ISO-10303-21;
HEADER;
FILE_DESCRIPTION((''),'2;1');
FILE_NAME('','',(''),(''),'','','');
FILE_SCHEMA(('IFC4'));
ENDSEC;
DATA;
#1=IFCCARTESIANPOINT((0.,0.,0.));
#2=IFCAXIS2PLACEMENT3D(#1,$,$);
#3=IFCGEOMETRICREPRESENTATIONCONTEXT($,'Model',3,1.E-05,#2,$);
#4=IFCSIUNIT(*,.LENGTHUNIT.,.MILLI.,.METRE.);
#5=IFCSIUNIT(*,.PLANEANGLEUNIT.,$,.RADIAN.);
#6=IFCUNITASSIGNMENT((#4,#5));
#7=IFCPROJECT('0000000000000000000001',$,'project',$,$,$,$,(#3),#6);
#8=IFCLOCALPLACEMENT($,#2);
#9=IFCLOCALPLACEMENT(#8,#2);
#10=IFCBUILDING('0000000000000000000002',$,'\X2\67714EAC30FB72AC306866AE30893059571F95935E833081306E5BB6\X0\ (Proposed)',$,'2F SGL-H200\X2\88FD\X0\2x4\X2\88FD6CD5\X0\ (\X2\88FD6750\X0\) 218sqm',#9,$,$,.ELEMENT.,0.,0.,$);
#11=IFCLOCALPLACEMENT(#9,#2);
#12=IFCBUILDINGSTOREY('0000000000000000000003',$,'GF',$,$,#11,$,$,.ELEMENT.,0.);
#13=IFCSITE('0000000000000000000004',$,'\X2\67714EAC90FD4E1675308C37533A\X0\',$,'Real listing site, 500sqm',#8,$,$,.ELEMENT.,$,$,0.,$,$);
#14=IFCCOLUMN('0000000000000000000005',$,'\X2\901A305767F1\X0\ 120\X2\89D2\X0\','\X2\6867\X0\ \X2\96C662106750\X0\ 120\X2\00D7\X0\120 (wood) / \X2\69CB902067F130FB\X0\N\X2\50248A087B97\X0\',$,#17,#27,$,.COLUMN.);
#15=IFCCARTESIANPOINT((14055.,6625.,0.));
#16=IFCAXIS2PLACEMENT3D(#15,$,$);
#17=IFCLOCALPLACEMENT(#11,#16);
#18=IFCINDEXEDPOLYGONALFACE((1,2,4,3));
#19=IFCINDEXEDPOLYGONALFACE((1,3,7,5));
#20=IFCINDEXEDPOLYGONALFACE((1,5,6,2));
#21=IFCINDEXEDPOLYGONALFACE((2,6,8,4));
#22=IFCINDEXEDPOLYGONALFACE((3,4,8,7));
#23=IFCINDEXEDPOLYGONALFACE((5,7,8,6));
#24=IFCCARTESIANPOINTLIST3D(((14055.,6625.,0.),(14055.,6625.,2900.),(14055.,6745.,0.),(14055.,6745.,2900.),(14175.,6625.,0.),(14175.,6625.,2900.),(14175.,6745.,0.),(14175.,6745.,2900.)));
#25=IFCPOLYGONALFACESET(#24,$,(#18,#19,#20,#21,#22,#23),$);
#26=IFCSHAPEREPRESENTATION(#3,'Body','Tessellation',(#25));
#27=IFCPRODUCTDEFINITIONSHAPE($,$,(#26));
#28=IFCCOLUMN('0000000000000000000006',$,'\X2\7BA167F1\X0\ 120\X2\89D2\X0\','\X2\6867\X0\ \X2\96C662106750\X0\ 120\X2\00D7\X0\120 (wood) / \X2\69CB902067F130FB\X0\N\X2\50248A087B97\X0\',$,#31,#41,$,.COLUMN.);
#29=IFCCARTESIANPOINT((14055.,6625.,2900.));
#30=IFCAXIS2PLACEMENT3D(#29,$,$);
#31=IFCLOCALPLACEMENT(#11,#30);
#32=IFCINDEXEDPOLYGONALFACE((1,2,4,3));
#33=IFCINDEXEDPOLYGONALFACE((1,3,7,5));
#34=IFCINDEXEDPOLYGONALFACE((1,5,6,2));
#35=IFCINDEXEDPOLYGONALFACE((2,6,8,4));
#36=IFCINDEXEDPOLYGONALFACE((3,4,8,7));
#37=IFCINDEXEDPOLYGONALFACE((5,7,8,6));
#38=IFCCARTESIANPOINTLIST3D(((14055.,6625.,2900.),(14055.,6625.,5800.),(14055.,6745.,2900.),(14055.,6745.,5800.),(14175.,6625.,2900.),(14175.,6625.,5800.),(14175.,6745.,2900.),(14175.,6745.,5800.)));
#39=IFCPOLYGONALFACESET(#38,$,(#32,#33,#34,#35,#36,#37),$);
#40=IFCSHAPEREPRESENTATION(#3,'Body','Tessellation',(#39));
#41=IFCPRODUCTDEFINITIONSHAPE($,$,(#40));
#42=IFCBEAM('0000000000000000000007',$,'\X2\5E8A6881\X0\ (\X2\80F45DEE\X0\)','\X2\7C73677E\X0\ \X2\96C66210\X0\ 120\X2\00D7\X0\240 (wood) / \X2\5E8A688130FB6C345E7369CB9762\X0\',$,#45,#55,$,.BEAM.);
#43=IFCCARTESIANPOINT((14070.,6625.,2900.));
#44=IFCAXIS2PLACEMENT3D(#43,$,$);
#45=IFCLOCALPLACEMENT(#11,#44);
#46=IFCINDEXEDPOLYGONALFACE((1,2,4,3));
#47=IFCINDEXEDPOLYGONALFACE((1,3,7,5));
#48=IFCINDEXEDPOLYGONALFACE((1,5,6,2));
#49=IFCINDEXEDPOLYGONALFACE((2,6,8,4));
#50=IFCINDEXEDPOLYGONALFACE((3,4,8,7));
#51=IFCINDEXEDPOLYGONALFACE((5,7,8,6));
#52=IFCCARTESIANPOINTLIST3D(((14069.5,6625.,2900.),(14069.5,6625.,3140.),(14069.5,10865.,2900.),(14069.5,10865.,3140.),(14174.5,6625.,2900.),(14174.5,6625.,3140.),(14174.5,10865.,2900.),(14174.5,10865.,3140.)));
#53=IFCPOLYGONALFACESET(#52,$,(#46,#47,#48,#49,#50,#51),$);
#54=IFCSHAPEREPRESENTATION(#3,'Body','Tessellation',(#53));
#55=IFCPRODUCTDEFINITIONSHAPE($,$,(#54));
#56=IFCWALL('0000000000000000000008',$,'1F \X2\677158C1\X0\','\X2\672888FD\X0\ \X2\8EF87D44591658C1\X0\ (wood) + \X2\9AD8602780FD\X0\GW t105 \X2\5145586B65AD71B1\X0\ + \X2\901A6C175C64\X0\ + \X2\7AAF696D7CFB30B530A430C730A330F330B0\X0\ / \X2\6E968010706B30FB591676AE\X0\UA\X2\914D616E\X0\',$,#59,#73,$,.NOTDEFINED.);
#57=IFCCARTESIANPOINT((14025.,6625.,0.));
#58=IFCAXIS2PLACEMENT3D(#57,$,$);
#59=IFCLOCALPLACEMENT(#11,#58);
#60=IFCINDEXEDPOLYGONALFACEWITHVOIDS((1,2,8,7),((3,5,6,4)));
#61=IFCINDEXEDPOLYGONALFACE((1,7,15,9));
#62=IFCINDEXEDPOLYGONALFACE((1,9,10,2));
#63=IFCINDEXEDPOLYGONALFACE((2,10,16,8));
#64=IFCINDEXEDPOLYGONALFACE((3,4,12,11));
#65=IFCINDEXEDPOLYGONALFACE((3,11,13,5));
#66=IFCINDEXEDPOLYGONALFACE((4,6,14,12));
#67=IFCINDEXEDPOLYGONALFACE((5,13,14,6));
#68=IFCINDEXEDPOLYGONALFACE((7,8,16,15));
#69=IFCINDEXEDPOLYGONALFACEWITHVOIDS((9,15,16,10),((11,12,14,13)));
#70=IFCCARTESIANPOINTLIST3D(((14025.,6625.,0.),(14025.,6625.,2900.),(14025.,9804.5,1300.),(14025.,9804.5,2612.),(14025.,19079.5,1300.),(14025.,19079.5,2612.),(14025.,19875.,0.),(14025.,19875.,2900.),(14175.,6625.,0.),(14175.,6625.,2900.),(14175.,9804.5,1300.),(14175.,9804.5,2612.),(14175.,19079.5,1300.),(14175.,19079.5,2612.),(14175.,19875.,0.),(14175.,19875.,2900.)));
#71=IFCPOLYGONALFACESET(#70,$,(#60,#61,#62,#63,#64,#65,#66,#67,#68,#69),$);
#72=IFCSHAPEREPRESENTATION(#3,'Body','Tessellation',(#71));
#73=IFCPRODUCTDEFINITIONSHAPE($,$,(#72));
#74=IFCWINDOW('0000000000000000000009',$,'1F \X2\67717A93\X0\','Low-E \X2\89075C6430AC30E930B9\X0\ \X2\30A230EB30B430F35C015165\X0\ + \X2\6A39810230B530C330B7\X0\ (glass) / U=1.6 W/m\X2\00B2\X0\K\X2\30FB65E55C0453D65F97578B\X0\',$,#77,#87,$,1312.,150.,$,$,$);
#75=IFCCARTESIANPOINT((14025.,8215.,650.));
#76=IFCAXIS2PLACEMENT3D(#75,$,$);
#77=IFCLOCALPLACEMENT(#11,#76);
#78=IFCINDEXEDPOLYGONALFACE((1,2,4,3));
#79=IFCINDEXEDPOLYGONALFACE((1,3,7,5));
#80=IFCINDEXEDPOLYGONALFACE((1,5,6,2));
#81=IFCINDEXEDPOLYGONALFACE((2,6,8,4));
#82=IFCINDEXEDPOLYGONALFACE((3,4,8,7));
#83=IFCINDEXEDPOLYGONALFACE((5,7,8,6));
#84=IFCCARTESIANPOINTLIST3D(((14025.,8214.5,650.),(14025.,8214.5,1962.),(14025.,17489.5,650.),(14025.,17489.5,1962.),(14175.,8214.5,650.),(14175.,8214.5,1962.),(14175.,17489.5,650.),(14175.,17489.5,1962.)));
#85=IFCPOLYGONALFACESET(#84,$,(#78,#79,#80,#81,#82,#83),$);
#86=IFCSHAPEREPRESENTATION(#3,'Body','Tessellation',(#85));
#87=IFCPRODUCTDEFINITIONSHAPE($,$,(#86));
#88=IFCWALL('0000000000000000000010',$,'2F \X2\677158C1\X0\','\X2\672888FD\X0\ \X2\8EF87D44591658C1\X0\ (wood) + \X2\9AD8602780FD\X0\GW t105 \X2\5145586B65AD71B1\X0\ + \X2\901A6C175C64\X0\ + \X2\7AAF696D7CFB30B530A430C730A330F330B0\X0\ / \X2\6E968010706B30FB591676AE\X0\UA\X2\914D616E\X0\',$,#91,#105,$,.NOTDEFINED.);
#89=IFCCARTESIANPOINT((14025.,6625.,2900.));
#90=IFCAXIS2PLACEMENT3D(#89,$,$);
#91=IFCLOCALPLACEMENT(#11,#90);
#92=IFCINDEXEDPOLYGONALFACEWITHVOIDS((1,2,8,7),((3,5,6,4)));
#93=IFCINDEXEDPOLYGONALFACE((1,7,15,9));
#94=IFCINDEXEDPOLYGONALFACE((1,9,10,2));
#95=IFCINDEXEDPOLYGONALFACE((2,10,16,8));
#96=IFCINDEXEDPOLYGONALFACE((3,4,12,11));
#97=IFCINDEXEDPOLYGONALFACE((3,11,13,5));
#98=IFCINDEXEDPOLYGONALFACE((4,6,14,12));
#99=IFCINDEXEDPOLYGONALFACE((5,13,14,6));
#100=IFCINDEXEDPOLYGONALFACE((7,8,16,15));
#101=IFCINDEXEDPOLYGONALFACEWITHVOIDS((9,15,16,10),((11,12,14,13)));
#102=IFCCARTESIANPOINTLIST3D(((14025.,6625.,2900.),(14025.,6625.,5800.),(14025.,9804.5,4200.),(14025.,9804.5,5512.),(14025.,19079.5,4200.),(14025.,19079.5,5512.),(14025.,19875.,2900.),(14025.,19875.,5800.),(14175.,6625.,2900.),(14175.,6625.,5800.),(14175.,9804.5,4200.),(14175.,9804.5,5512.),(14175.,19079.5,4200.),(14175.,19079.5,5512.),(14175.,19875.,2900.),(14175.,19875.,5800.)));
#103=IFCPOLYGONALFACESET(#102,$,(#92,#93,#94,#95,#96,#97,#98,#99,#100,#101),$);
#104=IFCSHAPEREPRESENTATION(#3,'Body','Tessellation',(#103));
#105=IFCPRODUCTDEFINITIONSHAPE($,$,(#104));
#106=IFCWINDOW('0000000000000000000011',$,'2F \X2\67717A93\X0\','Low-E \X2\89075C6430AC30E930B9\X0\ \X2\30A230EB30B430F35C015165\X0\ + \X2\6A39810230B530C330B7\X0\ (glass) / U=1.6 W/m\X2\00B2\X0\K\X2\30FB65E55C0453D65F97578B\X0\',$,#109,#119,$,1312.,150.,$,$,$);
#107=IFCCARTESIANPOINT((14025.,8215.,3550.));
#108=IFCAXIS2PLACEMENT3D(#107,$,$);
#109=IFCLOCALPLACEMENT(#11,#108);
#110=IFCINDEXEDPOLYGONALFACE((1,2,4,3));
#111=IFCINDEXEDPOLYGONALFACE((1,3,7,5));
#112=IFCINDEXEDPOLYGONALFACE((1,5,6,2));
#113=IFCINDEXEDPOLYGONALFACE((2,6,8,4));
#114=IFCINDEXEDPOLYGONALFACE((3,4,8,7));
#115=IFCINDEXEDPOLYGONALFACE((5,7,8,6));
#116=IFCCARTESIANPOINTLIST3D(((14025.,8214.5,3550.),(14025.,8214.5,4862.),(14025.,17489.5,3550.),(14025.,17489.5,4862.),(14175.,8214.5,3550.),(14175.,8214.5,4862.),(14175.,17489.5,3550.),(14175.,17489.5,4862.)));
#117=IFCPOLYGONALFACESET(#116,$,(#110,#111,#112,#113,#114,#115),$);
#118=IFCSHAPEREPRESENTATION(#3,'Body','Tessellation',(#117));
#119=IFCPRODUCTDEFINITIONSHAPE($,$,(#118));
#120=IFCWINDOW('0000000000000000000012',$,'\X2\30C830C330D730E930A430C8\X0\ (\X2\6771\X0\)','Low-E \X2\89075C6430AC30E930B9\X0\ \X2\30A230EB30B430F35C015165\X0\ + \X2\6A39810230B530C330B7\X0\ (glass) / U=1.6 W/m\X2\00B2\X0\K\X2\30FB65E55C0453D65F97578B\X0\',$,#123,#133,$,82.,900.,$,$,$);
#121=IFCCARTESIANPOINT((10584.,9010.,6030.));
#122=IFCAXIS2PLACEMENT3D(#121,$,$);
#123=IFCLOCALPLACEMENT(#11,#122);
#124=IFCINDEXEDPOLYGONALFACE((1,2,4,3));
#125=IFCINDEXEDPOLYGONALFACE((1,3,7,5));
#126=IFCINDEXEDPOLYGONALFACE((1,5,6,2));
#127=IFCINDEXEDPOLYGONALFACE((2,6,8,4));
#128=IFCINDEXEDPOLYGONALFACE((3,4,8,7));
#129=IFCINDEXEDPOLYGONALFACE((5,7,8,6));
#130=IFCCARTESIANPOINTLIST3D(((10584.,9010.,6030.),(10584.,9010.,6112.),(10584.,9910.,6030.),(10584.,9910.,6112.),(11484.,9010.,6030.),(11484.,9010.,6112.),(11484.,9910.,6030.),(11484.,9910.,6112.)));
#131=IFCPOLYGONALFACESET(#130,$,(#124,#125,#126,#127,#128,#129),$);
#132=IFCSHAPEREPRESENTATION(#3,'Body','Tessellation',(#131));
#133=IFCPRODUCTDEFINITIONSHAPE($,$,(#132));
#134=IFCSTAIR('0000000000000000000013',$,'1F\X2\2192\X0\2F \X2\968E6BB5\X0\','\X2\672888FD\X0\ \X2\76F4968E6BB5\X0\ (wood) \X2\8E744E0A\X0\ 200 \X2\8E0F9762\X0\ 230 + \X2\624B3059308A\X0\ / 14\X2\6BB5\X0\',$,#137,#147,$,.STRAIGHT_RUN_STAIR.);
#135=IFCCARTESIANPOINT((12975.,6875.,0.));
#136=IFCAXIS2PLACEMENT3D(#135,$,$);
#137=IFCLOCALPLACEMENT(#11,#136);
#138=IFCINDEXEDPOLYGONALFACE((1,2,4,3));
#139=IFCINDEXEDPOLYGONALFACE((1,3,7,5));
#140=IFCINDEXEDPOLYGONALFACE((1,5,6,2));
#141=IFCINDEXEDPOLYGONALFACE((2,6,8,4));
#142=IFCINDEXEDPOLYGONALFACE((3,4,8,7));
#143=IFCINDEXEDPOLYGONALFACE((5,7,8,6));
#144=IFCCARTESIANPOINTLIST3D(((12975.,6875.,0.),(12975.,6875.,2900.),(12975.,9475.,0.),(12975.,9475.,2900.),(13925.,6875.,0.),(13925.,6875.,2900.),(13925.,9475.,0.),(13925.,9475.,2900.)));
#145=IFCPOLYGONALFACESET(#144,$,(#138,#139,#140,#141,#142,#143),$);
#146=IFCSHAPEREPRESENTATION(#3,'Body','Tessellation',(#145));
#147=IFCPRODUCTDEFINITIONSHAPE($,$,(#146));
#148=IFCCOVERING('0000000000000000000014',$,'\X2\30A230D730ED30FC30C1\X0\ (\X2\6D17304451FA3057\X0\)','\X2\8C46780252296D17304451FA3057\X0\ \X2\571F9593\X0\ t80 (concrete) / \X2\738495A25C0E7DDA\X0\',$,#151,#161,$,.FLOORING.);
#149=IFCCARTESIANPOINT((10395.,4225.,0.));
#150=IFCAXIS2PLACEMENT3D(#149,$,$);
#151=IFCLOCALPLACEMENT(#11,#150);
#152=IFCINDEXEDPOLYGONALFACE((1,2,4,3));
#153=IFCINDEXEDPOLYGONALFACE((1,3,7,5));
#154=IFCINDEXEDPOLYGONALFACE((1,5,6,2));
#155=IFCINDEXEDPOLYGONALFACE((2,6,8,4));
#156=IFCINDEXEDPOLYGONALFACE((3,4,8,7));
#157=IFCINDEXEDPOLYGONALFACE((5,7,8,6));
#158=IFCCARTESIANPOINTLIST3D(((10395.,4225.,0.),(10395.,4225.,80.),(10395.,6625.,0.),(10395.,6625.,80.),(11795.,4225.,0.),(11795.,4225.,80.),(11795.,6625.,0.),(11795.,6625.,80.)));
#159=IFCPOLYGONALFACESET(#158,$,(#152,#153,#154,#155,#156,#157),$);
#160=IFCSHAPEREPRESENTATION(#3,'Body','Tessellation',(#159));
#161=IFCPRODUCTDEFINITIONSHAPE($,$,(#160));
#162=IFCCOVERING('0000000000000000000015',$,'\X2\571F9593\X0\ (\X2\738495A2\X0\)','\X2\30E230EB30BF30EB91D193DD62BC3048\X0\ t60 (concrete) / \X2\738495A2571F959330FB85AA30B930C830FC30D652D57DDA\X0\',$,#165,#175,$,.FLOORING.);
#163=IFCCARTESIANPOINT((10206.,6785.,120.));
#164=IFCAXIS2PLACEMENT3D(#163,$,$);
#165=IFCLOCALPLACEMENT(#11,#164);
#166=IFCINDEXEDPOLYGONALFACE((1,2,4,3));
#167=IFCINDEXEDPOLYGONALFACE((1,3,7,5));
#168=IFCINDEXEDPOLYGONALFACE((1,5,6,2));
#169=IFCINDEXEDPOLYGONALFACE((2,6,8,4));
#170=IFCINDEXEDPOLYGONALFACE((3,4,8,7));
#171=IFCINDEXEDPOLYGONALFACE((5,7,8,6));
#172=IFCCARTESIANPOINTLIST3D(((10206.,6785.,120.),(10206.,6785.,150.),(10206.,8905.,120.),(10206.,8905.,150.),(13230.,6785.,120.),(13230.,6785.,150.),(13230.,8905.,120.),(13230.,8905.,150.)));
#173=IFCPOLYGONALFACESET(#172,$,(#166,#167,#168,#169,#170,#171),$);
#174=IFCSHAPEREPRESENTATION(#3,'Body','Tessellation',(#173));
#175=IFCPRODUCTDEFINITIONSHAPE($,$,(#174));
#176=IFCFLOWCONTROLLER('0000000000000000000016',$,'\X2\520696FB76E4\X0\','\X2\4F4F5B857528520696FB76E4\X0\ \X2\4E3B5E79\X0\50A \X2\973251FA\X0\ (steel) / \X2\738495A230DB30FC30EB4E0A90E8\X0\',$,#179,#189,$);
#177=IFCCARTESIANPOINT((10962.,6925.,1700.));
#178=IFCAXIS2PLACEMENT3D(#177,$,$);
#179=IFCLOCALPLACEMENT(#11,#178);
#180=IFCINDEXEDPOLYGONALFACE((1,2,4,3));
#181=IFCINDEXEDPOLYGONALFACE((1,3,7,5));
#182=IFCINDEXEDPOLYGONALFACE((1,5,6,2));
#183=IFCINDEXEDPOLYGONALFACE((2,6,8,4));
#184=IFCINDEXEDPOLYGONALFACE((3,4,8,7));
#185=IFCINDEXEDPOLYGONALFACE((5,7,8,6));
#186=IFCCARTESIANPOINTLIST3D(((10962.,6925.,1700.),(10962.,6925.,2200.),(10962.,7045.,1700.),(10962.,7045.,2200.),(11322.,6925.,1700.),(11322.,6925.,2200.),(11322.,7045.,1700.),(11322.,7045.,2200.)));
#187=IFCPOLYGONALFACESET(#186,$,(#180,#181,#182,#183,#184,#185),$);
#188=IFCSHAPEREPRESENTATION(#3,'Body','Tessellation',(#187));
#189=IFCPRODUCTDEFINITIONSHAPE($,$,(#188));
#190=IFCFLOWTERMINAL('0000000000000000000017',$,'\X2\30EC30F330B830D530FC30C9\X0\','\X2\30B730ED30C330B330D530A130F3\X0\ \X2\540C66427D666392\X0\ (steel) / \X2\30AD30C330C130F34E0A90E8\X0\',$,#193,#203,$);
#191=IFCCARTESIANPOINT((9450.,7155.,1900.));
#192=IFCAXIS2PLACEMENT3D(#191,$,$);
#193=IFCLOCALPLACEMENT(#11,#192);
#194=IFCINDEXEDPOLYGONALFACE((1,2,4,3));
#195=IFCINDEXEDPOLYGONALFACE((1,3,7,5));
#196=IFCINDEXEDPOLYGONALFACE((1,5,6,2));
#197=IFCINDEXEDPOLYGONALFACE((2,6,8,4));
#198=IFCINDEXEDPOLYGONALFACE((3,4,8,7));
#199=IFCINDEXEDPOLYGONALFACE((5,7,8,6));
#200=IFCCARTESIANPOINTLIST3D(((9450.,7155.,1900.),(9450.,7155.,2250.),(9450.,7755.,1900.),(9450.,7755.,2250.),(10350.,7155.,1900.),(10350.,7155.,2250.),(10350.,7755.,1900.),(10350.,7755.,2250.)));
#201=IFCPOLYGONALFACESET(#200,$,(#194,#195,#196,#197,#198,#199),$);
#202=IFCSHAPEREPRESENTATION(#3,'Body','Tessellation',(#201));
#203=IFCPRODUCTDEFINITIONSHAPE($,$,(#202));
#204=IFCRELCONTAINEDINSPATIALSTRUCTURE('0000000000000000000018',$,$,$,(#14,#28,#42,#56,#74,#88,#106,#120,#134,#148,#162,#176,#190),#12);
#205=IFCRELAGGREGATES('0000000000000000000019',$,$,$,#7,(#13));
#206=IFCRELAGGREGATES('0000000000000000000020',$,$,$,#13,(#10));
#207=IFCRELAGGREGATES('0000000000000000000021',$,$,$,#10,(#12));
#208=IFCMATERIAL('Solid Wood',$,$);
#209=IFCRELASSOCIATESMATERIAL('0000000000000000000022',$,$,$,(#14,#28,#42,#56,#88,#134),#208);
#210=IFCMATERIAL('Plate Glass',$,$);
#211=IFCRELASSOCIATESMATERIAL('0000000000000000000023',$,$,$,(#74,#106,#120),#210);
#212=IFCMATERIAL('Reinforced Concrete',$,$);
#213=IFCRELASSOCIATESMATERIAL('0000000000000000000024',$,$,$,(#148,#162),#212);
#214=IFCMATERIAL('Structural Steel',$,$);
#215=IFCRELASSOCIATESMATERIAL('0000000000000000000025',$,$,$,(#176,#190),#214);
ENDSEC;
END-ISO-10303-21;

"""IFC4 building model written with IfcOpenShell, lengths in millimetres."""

from ifc_helpers import new_model, si_unit, frame, frame_2d, origin, place, context, project, spatial, rectangle, extrude, material, element, fill, save


model = new_model("IFC4")

# Units and contexts
model_context = context("Model", 3, precision=1e-05, world=origin())
ifc_project = project(units=[si_unit("LENGTHUNIT", "METRE", prefix="MILLI"), si_unit("PLANEANGLEUNIT", "RADIAN")], contexts=[model_context])

# Site, building, storey
site_placement = place(None, origin())
site = spatial("IfcSite", under=ifc_project, at=site_placement, Name="東京都世田谷区", ObjectType="Real listing site, 500sqm", CompositionType="ELEMENT", RefElevation=0.0)
building_placement = place(site_placement, origin())
building = spatial("IfcBuilding", under=site, at=building_placement, Name="東京・犬と暮らす土間広めの家 (Proposed)", ObjectType="2F SGL-H200製2x4製法 (製材) 218sqm", CompositionType="ELEMENT", ElevationOfRefHeight=0.0, ElevationOfTerrain=0.0)
storey_placement = place(building_placement, origin())
storey = spatial("IfcBuildingStorey", under=building, at=storey_placement, Name="GF", CompositionType="ELEMENT", Elevation=0.0)

# Columns
ifc_material_1 = material(Name="Solid Wood")
column_1_placement = place(storey_placement, frame((14055.0, 6625.0, 0.0)))
element("IfcColumn", 1, at=column_1_placement, inside=storey, material=ifc_material_1, Name="通し柱 120角", Description="桧 集成材 120×120 (wood) / 構造柱・N値計算", PredefinedType="COLUMN", context=model_context, shape_type="SweptSolid", body=[
    extrude(rectangle(XDim=120.0, YDim=120.0, at=frame_2d((60.0, 60.0))), frame((14055.0, 6625.0, 0.0)), (0.0, 0.0, 1.0), 2900.0),
])
column_2_placement = place(storey_placement, frame((14055.0, 6625.0, 2900.0)))
element("IfcColumn", 2, at=column_2_placement, inside=storey, material=ifc_material_1, Name="管柱 120角", Description="桧 集成材 120×120 (wood) / 構造柱・N値計算", PredefinedType="COLUMN", context=model_context, shape_type="SweptSolid", body=[
    extrude(rectangle(XDim=120.0, YDim=120.0, at=frame_2d((60.0, 60.0))), frame((14055.0, 6625.0, 2900.0)), (0.0, 0.0, 1.0), 2900.0),
])

# Beam
beam_1_placement = place(storey_placement, frame((14070.0, 6625.0, 2900.0)))
element("IfcBeam", 3, at=beam_1_placement, inside=storey, material=ifc_material_1, Name="床梁 (胴差)", Description="米松 集成 120×240 (wood) / 床梁・水平構面", PredefinedType="BEAM", context=model_context, shape_type="SweptSolid", body=[
    extrude(rectangle(XDim=105.0, YDim=4240.0, at=frame_2d((52.0, 2120.0))), frame((14070.0, 6625.0, 2900.0)), (0.0, 0.0, 1.0), 240.0),
])

# Wall, opening, window
wall_1_placement = place(storey_placement, frame((14025.0, 6625.0, 0.0)))
wall_1 = element("IfcWall", 4, at=wall_1_placement, inside=storey, material=ifc_material_1, Name="1F 東壁", Description="木製 軸組外壁 (wood) + 高性能GW t105 充填断熱 + 通気層 + 窯業系サイディング / 準耐火・外皮UA配慮", PredefinedType="NOTDEFINED", context=model_context, shape_type="SweptSolid", body=[
    extrude(rectangle(XDim=150.0, YDim=13250.0, at=frame_2d((75.0, 6625.0))), frame((14025.0, 6625.0, 0.0)), (0.0, 0.0, 1.0), 2900.0),
])
opening_1_placement = place(storey_placement, frame((14025.0, 8215.0, 650.0)))
opening_1 = element("IfcOpeningElement", 5, at=opening_1_placement, cuts=wall_1, PredefinedType="NOTDEFINED", context=model_context, shape_type="SweptSolid", body=[
    extrude(rectangle(XDim=150.0, YDim=9275.0, at=frame_2d((75.0, 4637.0))), frame((14025.0, 8215.0, 650.0)), (0.0, 0.0, 1.0), 1312.0),
])
ifc_material_2 = material(Name="Plate Glass")
window_1_placement = place(storey_placement, frame((14025.0, 8215.0, 650.0)))
window_1 = element("IfcWindow", 6, at=window_1_placement, inside=storey, material=ifc_material_2, Name="1F 東窓", Description="Low-E 複層ガラス アルゴン封入 + 樹脂サッシ (glass) / U=1.6 W/m²K・日射取得型", OverallHeight=1312.0, OverallWidth=150.0, context=model_context, shape_type="SweptSolid", body=[
    extrude(rectangle(XDim=150.0, YDim=9275.0, at=frame_2d((75.0, 4637.0))), frame((14025.0, 8215.0, 650.0)), (0.0, 0.0, 1.0), 1312.0),
])
fill(opening_1, window_1)

# Wall, opening, window
wall_2_placement = place(storey_placement, frame((14025.0, 6625.0, 2900.0)))
wall_2 = element("IfcWall", 7, at=wall_2_placement, inside=storey, material=ifc_material_1, Name="2F 東壁", Description="木製 軸組外壁 (wood) + 高性能GW t105 充填断熱 + 通気層 + 窯業系サイディング / 準耐火・外皮UA配慮", PredefinedType="NOTDEFINED", context=model_context, shape_type="SweptSolid", body=[
    extrude(rectangle(XDim=150.0, YDim=13250.0, at=frame_2d((75.0, 6625.0))), frame((14025.0, 6625.0, 2900.0)), (0.0, 0.0, 1.0), 2900.0),
])
opening_2_placement = place(storey_placement, frame((14025.0, 8215.0, 3550.0)))
opening_2 = element("IfcOpeningElement", 8, at=opening_2_placement, cuts=wall_2, PredefinedType="NOTDEFINED", context=model_context, shape_type="SweptSolid", body=[
    extrude(rectangle(XDim=150.0, YDim=9275.0, at=frame_2d((75.0, 4637.0))), frame((14025.0, 8215.0, 3550.0)), (0.0, 0.0, 1.0), 1312.0),
])
window_2_placement = place(storey_placement, frame((14025.0, 8215.0, 3550.0)))
window_2 = element("IfcWindow", 9, at=window_2_placement, inside=storey, material=ifc_material_2, Name="2F 東窓", Description="Low-E 複層ガラス アルゴン封入 + 樹脂サッシ (glass) / U=1.6 W/m²K・日射取得型", OverallHeight=1312.0, OverallWidth=150.0, context=model_context, shape_type="SweptSolid", body=[
    extrude(rectangle(XDim=150.0, YDim=9275.0, at=frame_2d((75.0, 4637.0))), frame((14025.0, 8215.0, 3550.0)), (0.0, 0.0, 1.0), 1312.0),
])
fill(opening_2, window_2)

# Window
window_3_placement = place(storey_placement, frame((10584.0, 9010.0, 6030.0)))
element("IfcWindow", 10, at=window_3_placement, inside=storey, material=ifc_material_2, Name="トップライト (東)", Description="Low-E 複層ガラス アルゴン封入 + 樹脂サッシ (glass) / U=1.6 W/m²K・日射取得型", OverallHeight=82.0, OverallWidth=900.0, context=model_context, shape_type="SweptSolid", body=[
    extrude(rectangle(XDim=900.0, YDim=900.0, at=frame_2d((450.0, 450.0))), frame((10584.0, 9010.0, 6030.0)), (0.0, 0.0, 1.0), 82.0),
])

# Stair
stair_placement = place(storey_placement, frame((12975.0, 6875.0, 0.0)))
element("IfcStair", 11, at=stair_placement, inside=storey, material=ifc_material_1, Name="1F→2F 階段", Description="木製 直階段 (wood) 蹴上 200 踏面 230 + 手すり / 14段", PredefinedType="STRAIGHT_RUN_STAIR", context=model_context, shape_type="SweptSolid", body=[
    extrude(rectangle(XDim=950.0, YDim=2600.0, at=frame_2d((475.0, 1300.0))), frame((12975.0, 6875.0, 0.0)), (0.0, 0.0, 1.0), 2900.0),
])

# Coverings
ifc_material_3 = material(Name="Reinforced Concrete")
covering_1_placement = place(storey_placement, frame((10395.0, 4225.0, 0.0)))
element("IfcCovering", 12, at=covering_1_placement, inside=storey, material=ifc_material_3, Name="アプローチ (洗い出し)", Description="豆砂利洗い出し 土間 t80 (concrete) / 玄関導線", PredefinedType="FLOORING", context=model_context, shape_type="SweptSolid", body=[
    extrude(rectangle(XDim=1400.0, YDim=2400.0, at=frame_2d((700.0, 1200.0))), frame((10395.0, 4225.0, 0.0)), (0.0, 0.0, 1.0), 80.0),
])
covering_2_placement = place(storey_placement, frame((10206.0, 6785.0, 120.0)))
element("IfcCovering", 13, at=covering_2_placement, inside=storey, material=ifc_material_3, Name="土間 (玄関)", Description="モルタル金鏝押え t60 (concrete) / 玄関土間・薪ストーブ動線", PredefinedType="FLOORING", context=model_context, shape_type="SweptSolid", body=[
    extrude(rectangle(XDim=3024.0, YDim=2120.0, at=frame_2d((1512.0, 1060.0))), frame((10206.0, 6785.0, 120.0)), (0.0, 0.0, 1.0), 30.0),
])

# Flow controller
ifc_material_4 = material(Name="Structural Steel")
flow_controller_placement = place(storey_placement, frame((10962.0, 6925.0, 1700.0)))
element("IfcFlowController", 14, at=flow_controller_placement, inside=storey, material=ifc_material_4, Name="分電盤", Description="住宅用分電盤 主幹50A 露出 (steel) / 玄関ホール上部", context=model_context, shape_type="SweptSolid", body=[
    extrude(rectangle(XDim=360.0, YDim=120.0, at=frame_2d((180.0, 60.0))), frame((10962.0, 6925.0, 1700.0)), (0.0, 0.0, 1.0), 500.0),
])

# Flow terminal
flow_terminal_1_placement = place(storey_placement, frame((9450.0, 7155.0, 1900.0)))
element("IfcFlowTerminal", 15, at=flow_terminal_1_placement, inside=storey, material=ifc_material_4, Name="レンジフード", Description="シロッコファン 同時給排 (steel) / キッチン上部", context=model_context, shape_type="SweptSolid", body=[
    extrude(rectangle(XDim=900.0, YDim=600.0, at=frame_2d((450.0, 300.0))), frame((9450.0, 7155.0, 1900.0)), (0.0, 0.0, 1.0), 350.0),
])

save(model, "model.ifc")
